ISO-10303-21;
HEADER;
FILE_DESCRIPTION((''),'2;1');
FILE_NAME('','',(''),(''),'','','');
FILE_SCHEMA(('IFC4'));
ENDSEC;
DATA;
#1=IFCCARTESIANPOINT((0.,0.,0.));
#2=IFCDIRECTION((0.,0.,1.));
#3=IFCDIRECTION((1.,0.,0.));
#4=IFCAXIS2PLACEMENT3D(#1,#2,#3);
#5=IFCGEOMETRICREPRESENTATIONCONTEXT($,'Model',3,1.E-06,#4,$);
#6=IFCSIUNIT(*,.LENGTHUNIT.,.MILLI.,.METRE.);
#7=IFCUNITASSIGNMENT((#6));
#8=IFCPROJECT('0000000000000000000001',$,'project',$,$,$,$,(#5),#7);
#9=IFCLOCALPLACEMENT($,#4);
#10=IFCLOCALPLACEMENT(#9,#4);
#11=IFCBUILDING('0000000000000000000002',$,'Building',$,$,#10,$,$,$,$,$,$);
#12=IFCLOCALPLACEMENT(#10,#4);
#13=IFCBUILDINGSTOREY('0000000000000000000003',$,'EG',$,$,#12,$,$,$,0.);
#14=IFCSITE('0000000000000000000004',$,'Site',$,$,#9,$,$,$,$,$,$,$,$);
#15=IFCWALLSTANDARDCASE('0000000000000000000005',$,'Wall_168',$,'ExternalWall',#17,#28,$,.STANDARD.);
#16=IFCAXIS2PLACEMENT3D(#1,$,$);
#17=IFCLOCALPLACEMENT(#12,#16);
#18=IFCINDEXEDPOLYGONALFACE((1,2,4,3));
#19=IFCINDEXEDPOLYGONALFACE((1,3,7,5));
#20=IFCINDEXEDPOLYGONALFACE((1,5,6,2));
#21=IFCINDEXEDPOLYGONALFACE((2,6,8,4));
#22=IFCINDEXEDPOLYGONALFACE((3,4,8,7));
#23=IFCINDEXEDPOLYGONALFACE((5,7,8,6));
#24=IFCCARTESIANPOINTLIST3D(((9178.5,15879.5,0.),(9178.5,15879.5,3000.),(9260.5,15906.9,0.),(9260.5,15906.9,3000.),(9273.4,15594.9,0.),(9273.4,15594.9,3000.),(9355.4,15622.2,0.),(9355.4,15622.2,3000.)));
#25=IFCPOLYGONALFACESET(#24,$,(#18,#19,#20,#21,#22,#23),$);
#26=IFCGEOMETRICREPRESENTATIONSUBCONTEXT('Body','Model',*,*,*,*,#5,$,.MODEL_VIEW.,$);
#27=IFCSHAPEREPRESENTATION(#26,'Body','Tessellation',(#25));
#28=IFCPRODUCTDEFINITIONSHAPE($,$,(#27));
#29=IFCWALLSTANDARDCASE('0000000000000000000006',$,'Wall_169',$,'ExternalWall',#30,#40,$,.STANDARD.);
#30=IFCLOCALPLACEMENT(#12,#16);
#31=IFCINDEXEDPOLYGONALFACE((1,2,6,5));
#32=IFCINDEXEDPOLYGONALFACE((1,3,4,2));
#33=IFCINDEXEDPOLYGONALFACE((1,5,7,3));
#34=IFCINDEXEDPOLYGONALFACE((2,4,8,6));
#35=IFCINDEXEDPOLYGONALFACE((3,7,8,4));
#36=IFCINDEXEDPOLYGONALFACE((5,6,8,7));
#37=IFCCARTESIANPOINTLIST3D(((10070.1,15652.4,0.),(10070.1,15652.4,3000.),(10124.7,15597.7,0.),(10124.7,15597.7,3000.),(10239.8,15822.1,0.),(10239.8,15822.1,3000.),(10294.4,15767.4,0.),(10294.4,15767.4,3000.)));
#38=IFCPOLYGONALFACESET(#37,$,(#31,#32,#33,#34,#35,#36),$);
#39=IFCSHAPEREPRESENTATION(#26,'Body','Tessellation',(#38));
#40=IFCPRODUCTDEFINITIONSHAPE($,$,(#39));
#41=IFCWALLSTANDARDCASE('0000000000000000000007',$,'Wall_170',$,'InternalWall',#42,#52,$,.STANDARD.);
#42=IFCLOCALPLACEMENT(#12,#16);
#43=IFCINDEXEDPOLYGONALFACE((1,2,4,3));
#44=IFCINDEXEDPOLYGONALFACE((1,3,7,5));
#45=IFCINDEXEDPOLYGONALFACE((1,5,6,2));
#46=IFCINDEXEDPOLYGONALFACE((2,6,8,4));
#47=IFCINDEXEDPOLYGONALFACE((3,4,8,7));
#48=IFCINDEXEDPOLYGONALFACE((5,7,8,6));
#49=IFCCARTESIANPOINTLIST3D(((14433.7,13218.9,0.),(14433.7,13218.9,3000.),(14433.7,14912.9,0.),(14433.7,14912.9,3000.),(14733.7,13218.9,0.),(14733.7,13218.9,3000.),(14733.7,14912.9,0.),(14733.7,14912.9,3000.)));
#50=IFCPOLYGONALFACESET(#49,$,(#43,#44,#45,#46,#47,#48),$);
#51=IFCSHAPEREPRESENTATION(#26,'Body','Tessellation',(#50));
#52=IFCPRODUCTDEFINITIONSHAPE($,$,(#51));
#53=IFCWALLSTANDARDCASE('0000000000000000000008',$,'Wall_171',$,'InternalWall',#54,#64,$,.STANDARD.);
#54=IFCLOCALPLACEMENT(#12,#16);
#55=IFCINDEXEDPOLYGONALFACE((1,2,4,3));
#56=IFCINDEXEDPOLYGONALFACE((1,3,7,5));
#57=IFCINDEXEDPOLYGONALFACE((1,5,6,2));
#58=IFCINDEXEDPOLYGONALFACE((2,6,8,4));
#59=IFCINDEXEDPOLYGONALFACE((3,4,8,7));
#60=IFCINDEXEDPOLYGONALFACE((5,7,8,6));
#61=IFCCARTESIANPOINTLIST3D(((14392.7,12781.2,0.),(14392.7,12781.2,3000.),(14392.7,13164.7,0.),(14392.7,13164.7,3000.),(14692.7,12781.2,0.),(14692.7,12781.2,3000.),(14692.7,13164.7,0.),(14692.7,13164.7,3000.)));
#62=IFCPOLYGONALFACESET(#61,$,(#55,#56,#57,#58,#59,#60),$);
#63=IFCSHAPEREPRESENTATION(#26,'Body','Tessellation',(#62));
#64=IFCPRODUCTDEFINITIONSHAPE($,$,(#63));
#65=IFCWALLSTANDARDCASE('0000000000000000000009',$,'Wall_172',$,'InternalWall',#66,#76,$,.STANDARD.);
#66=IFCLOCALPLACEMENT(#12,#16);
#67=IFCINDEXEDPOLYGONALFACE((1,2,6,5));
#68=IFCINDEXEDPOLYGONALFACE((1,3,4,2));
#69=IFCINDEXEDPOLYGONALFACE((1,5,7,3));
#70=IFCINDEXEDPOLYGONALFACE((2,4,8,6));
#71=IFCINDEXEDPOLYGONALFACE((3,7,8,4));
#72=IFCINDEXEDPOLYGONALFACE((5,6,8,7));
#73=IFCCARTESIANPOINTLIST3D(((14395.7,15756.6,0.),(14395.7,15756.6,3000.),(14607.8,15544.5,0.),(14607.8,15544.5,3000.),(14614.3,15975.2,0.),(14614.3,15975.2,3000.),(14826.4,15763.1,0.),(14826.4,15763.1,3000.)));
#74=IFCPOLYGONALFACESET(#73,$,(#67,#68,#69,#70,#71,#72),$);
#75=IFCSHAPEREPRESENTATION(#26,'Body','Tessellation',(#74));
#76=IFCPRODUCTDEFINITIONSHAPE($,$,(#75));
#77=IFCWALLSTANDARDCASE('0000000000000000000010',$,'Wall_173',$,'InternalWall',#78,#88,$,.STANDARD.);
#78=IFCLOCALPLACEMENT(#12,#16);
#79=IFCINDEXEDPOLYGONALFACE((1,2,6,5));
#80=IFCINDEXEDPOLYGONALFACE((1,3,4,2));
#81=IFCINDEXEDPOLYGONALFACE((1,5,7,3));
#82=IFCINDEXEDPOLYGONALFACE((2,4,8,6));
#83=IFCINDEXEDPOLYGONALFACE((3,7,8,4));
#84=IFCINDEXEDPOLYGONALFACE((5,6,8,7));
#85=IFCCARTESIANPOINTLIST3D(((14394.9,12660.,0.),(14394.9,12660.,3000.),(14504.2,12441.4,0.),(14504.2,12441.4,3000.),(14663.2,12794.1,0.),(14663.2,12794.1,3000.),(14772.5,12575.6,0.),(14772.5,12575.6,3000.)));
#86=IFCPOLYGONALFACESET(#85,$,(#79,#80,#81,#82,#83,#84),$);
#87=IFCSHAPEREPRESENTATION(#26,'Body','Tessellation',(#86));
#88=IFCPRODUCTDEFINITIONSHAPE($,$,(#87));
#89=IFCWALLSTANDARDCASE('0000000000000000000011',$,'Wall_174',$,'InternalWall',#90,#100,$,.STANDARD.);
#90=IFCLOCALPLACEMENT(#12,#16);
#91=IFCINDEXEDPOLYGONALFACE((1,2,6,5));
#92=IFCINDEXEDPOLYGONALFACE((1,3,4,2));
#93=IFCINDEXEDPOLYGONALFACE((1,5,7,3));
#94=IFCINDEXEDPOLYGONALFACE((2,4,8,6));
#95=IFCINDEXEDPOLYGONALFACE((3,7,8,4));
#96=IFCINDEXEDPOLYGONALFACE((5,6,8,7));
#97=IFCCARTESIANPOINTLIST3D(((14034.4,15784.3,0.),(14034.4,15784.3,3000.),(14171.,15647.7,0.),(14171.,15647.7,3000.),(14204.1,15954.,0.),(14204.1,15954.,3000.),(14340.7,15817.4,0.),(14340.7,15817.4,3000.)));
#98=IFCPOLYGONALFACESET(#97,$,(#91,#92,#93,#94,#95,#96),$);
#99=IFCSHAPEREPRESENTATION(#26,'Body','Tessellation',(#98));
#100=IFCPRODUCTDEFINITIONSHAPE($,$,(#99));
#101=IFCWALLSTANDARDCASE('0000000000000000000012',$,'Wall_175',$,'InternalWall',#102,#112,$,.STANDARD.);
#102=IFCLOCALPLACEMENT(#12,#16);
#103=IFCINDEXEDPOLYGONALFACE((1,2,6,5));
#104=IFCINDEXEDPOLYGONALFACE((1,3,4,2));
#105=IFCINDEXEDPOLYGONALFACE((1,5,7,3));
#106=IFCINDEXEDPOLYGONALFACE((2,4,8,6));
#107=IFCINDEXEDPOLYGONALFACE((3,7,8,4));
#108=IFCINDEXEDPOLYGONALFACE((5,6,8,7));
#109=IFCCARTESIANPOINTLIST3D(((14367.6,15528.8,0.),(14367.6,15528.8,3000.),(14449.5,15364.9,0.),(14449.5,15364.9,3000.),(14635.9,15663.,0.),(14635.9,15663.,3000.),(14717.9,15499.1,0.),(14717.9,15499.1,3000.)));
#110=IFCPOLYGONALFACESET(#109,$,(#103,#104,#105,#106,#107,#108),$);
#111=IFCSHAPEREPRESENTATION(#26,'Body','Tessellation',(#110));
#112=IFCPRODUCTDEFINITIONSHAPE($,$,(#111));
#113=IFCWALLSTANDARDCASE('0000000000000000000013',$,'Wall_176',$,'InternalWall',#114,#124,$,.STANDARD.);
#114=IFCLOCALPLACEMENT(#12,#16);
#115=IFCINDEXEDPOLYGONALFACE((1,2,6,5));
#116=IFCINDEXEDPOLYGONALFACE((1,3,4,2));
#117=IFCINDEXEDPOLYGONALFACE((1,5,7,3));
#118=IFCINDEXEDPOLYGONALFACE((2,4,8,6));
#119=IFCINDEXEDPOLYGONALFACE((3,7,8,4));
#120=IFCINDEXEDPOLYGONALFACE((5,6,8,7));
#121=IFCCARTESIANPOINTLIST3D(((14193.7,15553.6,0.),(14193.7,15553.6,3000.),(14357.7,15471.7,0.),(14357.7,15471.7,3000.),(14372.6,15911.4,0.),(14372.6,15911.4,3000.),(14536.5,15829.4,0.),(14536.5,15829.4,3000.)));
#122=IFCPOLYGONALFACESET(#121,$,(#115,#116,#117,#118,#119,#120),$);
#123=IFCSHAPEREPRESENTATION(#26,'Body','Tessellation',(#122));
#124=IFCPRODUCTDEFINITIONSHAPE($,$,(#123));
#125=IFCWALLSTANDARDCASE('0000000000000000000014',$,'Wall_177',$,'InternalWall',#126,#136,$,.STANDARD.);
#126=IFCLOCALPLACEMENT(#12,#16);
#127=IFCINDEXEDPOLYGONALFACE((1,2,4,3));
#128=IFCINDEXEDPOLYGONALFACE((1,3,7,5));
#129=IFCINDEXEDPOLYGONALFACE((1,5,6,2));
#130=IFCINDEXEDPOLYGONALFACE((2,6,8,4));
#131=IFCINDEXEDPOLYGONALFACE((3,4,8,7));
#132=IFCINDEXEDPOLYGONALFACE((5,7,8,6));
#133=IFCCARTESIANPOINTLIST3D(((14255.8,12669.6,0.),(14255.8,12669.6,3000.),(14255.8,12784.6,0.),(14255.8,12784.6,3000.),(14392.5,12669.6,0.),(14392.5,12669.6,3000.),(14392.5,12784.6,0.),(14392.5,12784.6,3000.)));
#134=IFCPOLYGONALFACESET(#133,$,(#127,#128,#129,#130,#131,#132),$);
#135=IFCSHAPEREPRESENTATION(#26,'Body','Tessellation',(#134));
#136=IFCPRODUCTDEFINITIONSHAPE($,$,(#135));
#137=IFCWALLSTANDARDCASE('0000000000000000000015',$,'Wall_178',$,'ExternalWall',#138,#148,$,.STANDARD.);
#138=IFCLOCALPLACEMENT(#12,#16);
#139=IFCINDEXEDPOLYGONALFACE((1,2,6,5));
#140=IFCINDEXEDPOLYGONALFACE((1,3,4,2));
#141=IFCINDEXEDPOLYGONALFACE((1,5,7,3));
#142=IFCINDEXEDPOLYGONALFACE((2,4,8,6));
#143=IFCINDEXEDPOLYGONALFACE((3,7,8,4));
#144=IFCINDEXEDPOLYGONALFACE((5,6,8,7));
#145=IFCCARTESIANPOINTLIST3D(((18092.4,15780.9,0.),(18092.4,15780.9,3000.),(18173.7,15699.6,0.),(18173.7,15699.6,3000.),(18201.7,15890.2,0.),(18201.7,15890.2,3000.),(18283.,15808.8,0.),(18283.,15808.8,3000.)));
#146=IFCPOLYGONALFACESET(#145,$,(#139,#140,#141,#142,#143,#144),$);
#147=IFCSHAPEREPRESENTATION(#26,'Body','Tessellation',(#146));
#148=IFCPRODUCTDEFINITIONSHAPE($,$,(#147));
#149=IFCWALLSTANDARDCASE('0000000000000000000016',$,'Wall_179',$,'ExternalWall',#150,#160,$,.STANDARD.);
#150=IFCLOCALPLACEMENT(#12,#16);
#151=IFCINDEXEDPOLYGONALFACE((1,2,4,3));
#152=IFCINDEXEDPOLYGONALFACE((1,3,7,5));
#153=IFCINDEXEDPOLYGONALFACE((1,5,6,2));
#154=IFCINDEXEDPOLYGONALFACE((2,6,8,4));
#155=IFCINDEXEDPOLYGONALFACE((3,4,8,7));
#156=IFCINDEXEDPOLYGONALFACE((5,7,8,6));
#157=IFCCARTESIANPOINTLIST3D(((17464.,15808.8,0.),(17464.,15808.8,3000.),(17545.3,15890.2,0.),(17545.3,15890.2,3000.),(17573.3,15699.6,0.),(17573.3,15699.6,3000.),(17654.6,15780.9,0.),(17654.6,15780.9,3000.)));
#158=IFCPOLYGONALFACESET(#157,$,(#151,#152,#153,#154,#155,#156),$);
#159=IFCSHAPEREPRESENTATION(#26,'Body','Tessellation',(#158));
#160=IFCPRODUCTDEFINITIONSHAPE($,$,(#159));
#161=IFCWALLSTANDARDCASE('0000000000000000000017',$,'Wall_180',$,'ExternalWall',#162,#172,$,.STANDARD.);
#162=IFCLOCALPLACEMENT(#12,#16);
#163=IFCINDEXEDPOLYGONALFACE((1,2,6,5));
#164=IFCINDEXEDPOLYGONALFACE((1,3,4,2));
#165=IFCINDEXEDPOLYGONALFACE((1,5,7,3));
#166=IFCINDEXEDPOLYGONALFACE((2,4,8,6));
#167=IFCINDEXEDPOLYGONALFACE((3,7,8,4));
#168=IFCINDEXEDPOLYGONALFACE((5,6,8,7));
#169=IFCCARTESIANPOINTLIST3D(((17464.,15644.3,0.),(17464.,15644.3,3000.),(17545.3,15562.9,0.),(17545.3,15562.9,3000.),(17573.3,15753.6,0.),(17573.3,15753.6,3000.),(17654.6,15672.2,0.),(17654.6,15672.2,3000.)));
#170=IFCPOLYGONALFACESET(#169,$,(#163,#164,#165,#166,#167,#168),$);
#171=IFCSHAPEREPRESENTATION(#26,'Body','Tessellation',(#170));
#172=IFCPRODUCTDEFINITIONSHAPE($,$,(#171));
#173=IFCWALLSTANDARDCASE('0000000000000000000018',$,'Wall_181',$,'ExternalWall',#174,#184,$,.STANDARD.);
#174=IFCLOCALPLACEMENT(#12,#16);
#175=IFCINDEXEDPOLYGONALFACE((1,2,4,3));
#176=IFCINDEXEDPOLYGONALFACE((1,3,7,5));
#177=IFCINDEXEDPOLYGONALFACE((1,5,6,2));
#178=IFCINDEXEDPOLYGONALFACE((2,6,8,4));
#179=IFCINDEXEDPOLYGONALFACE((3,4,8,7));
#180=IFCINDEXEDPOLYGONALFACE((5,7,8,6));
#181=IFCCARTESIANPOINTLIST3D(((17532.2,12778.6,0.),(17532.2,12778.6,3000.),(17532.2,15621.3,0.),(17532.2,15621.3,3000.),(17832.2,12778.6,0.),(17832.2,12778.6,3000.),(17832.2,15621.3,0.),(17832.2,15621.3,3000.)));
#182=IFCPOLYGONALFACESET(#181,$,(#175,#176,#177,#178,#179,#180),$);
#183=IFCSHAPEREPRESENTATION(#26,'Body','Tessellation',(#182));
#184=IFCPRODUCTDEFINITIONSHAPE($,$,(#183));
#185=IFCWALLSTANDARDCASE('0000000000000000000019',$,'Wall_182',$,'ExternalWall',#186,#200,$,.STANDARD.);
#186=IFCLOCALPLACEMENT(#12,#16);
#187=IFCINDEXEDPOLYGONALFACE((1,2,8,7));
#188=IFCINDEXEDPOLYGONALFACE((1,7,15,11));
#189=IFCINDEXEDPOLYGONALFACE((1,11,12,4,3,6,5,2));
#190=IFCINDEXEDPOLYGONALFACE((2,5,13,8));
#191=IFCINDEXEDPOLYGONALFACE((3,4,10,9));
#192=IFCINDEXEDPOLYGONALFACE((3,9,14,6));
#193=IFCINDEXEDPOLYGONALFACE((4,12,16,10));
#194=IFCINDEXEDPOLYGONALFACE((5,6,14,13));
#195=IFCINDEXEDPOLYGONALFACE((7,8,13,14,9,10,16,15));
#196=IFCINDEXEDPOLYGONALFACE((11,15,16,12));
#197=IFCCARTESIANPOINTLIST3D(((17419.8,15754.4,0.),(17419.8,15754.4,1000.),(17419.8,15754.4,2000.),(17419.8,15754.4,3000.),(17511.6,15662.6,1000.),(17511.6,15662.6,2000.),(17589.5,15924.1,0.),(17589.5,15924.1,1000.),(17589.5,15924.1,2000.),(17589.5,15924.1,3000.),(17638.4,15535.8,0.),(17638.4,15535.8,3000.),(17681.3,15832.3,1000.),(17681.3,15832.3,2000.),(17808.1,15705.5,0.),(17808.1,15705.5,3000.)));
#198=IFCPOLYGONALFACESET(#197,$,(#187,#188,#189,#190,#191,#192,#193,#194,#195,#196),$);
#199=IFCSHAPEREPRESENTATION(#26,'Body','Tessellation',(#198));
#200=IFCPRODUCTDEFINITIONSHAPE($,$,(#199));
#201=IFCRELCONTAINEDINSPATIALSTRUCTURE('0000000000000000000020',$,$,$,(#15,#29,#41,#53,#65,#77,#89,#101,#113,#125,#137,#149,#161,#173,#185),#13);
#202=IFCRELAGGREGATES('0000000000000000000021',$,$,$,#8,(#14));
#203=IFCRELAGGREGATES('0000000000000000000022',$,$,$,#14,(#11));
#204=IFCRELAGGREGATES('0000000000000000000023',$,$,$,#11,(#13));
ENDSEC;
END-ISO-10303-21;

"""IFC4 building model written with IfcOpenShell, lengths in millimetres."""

from ifc_helpers import new_model, si_unit, frame, origin_with_axes, place, context, subcontext, project, spatial, rectangle, extrude, element, save


model = new_model("IFC4")

# Units and contexts
model_context = context("Model", 3, precision=1e-06, world=origin_with_axes())
body_context = subcontext(model_context, "Body", "Model", "MODEL_VIEW")
ifc_project = project(units=[si_unit("LENGTHUNIT", "METRE", prefix="MILLI")], contexts=[model_context])

# Site, building, storey
site_placement = place(None, origin_with_axes())
site = spatial("IfcSite", under=ifc_project, at=site_placement, Name="Site")
building_placement = place(site_placement, origin_with_axes())
building = spatial("IfcBuilding", under=site, at=building_placement, Name="Building")
storey_placement = place(building_placement, origin_with_axes())
storey = spatial("IfcBuildingStorey", under=building, at=storey_placement, Name="EG", Elevation=0.0)

# Walls
wall_1_placement = place(storey_placement, origin_with_axes())
element("IfcWallStandardCase", 1, at=wall_1_placement, inside=storey, Name="Wall_168", ObjectType="ExternalWall", PredefinedType="STANDARD", context=body_context, shape_type="SweptSolid", body=[
    extrude(rectangle(XDim=86.4, YDim=300.0), frame((9266.9, 15750.9, 0.0), z_axis=(0.0, 0.0, 1.0), x_axis=(0.948683, 0.316228, 0.0)), (0.0, 0.0, 1.0), 3000.0),
])
wall_2_placement = place(storey_placement, origin_with_axes())
element("IfcWallStandardCase", 2, at=wall_2_placement, inside=storey, Name="Wall_169", ObjectType="ExternalWall", PredefinedType="STANDARD", context=body_context, shape_type="SweptSolid", body=[
    extrude(rectangle(XDim=77.3, YDim=240.0), frame((10182.2, 15709.9, 0.0), z_axis=(0.0, 0.0, 1.0), x_axis=(0.707107, -0.707107, 0.0)), (0.0, 0.0, 1.0), 3000.0),
])
wall_3_placement = place(storey_placement, origin_with_axes())
element("IfcWallStandardCase", 3, at=wall_3_placement, inside=storey, Name="Wall_170", ObjectType="InternalWall", PredefinedType="STANDARD", context=body_context, shape_type="SweptSolid", body=[
    extrude(rectangle(XDim=1694.0, YDim=300.0), frame((14583.7, 14065.9, 0.0), z_axis=(0.0, 0.0, 1.0), x_axis=(0.0, -1.0, 0.0)), (0.0, 0.0, 1.0), 3000.0),
])
wall_4_placement = place(storey_placement, origin_with_axes())
element("IfcWallStandardCase", 4, at=wall_4_placement, inside=storey, Name="Wall_171", ObjectType="InternalWall", PredefinedType="STANDARD", context=body_context, shape_type="SweptSolid", body=[
    extrude(rectangle(XDim=383.5, YDim=300.0), frame((14542.7, 12973.0, 0.0), z_axis=(0.0, 0.0, 1.0), x_axis=(0.0, -1.0, 0.0)), (0.0, 0.0, 1.0), 3000.0),
])
wall_5_placement = place(storey_placement, origin_with_axes())
element("IfcWallStandardCase", 5, at=wall_5_placement, inside=storey, Name="Wall_172", ObjectType="InternalWall", PredefinedType="STANDARD", context=body_context, shape_type="SweptSolid", body=[
    extrude(rectangle(XDim=309.1, YDim=300.0), frame((14611.0, 15759.9, 0.0), z_axis=(0.0, 0.0, 1.0), x_axis=(0.707107, 0.707107, 0.0)), (0.0, 0.0, 1.0), 3000.0),
])
wall_6_placement = place(storey_placement, origin_with_axes())
element("IfcWallStandardCase", 6, at=wall_6_placement, inside=storey, Name="Wall_173", ObjectType="InternalWall", PredefinedType="STANDARD", context=body_context, shape_type="SweptSolid", body=[
    extrude(rectangle(XDim=244.4, YDim=300.0), frame((14583.7, 12617.8, 0.0), z_axis=(0.0, 0.0, 1.0), x_axis=(0.447214, -0.894427, 0.0)), (0.0, 0.0, 1.0), 3000.0),
])
wall_7_placement = place(storey_placement, origin_with_axes())
element("IfcWallStandardCase", 7, at=wall_7_placement, inside=storey, Name="Wall_174", ObjectType="InternalWall", PredefinedType="STANDARD", context=body_context, shape_type="SweptSolid", body=[
    extrude(rectangle(XDim=193.2, YDim=240.0), frame((14187.5, 15800.8, 0.0), z_axis=(0.0, 0.0, 1.0), x_axis=(-0.707107, 0.707107, 0.0)), (0.0, 0.0, 1.0), 3000.0),
])
wall_8_placement = place(storey_placement, origin_with_axes())
element("IfcWallStandardCase", 8, at=wall_8_placement, inside=storey, Name="Wall_175", ObjectType="InternalWall", PredefinedType="STANDARD", context=body_context, shape_type="SweptSolid", body=[
    extrude(rectangle(XDim=183.3, YDim=300.0), frame((14542.7, 15514.0, 0.0), z_axis=(0.0, 0.0, 1.0), x_axis=(0.447214, -0.894427, 0.0)), (0.0, 0.0, 1.0), 3000.0),
])
wall_9_placement = place(storey_placement, origin_with_axes())
element("IfcWallStandardCase", 9, at=wall_9_placement, inside=storey, Name="Wall_176", ObjectType="InternalWall", PredefinedType="STANDARD", context=body_context, shape_type="SweptSolid", body=[
    extrude(rectangle(XDim=183.3, YDim=400.0), frame((14365.1, 15691.5, 0.0), z_axis=(0.0, 0.0, 1.0), x_axis=(-0.894427, 0.447214, 0.0)), (0.0, 0.0, 1.0), 3000.0),
])
wall_10_placement = place(storey_placement, origin_with_axes())
element("IfcWallStandardCase", 10, at=wall_10_placement, inside=storey, Name="Wall_177", ObjectType="InternalWall", PredefinedType="STANDARD", context=body_context, shape_type="SweptSolid", body=[
    extrude(rectangle(XDim=136.6, YDim=115.0), frame((14324.1, 12727.1, 0.0), z_axis=(0.0, 0.0, 1.0), x_axis=(-1.0, 0.0, 0.0)), (0.0, 0.0, 1.0), 3000.0),
])
wall_11_placement = place(storey_placement, origin_with_axes())
element("IfcWallStandardCase", 11, at=wall_11_placement, inside=storey, Name="Wall_178", ObjectType="ExternalWall", PredefinedType="STANDARD", context=body_context, shape_type="SweptSolid", body=[
    extrude(rectangle(XDim=154.6, YDim=115.0), frame((18187.7, 15794.9, 0.0), z_axis=(0.0, 0.0, 1.0), x_axis=(0.707107, 0.707107, 0.0)), (0.0, 0.0, 1.0), 3000.0),
])
wall_12_placement = place(storey_placement, origin_with_axes())
element("IfcWallStandardCase", 12, at=wall_12_placement, inside=storey, Name="Wall_179", ObjectType="ExternalWall", PredefinedType="STANDARD", context=body_context, shape_type="SweptSolid", body=[
    extrude(rectangle(XDim=154.6, YDim=115.0), frame((17559.3, 15794.9, 0.0), z_axis=(0.0, 0.0, 1.0), x_axis=(-0.707107, 0.707107, 0.0)), (0.0, 0.0, 1.0), 3000.0),
])
wall_13_placement = place(storey_placement, origin_with_axes())
element("IfcWallStandardCase", 13, at=wall_13_placement, inside=storey, Name="Wall_180", ObjectType="ExternalWall", PredefinedType="STANDARD", context=body_context, shape_type="SweptSolid", body=[
    extrude(rectangle(XDim=154.6, YDim=115.0), frame((17559.3, 15658.2, 0.0), z_axis=(0.0, 0.0, 1.0), x_axis=(-0.707107, -0.707107, 0.0)), (0.0, 0.0, 1.0), 3000.0),
])
wall_14_placement = place(storey_placement, origin_with_axes())
element("IfcWallStandardCase", 14, at=wall_14_placement, inside=storey, Name="Wall_181", ObjectType="ExternalWall", PredefinedType="STANDARD", context=body_context, shape_type="SweptSolid", body=[
    extrude(rectangle(XDim=2842.7, YDim=300.0), frame((17682.2, 14199.9, 0.0), z_axis=(0.0, 0.0, 1.0), x_axis=(0.0, -1.0, 0.0)), (0.0, 0.0, 1.0), 3000.0),
])

# Wall, opening
wall_15_placement = place(storey_placement, origin_with_axes())
wall_15 = element("IfcWallStandardCase", 15, at=wall_15_placement, inside=storey, Name="Wall_182", ObjectType="ExternalWall", PredefinedType="STANDARD", context=body_context, shape_type="SweptSolid", body=[
    extrude(rectangle(XDim=309.1, YDim=240.0), frame((17613.9, 15730.0, 0.0), z_axis=(0.0, 0.0, 1.0), x_axis=(-0.707107, 0.707107, 0.0)), (0.0, 0.0, 1.0), 3000.0),
])
opening_1_placement = place(wall_15_placement, origin_with_axes())
element("IfcOpeningElement", 16, at=opening_1_placement, inside=storey, cuts=wall_15, context=body_context, shape_type="SweptSolid", body=[
    extrude(rectangle(XDim=810.2, YDim=240.0), frame((17310.0, 16033.9, 1000.0), z_axis=(0.0, 0.0, 1.0), x_axis=(-0.707107, 0.707107, 0.0)), (0.0, 0.0, 1.0), 1000.0),
])

save(model, "model.ifc")
